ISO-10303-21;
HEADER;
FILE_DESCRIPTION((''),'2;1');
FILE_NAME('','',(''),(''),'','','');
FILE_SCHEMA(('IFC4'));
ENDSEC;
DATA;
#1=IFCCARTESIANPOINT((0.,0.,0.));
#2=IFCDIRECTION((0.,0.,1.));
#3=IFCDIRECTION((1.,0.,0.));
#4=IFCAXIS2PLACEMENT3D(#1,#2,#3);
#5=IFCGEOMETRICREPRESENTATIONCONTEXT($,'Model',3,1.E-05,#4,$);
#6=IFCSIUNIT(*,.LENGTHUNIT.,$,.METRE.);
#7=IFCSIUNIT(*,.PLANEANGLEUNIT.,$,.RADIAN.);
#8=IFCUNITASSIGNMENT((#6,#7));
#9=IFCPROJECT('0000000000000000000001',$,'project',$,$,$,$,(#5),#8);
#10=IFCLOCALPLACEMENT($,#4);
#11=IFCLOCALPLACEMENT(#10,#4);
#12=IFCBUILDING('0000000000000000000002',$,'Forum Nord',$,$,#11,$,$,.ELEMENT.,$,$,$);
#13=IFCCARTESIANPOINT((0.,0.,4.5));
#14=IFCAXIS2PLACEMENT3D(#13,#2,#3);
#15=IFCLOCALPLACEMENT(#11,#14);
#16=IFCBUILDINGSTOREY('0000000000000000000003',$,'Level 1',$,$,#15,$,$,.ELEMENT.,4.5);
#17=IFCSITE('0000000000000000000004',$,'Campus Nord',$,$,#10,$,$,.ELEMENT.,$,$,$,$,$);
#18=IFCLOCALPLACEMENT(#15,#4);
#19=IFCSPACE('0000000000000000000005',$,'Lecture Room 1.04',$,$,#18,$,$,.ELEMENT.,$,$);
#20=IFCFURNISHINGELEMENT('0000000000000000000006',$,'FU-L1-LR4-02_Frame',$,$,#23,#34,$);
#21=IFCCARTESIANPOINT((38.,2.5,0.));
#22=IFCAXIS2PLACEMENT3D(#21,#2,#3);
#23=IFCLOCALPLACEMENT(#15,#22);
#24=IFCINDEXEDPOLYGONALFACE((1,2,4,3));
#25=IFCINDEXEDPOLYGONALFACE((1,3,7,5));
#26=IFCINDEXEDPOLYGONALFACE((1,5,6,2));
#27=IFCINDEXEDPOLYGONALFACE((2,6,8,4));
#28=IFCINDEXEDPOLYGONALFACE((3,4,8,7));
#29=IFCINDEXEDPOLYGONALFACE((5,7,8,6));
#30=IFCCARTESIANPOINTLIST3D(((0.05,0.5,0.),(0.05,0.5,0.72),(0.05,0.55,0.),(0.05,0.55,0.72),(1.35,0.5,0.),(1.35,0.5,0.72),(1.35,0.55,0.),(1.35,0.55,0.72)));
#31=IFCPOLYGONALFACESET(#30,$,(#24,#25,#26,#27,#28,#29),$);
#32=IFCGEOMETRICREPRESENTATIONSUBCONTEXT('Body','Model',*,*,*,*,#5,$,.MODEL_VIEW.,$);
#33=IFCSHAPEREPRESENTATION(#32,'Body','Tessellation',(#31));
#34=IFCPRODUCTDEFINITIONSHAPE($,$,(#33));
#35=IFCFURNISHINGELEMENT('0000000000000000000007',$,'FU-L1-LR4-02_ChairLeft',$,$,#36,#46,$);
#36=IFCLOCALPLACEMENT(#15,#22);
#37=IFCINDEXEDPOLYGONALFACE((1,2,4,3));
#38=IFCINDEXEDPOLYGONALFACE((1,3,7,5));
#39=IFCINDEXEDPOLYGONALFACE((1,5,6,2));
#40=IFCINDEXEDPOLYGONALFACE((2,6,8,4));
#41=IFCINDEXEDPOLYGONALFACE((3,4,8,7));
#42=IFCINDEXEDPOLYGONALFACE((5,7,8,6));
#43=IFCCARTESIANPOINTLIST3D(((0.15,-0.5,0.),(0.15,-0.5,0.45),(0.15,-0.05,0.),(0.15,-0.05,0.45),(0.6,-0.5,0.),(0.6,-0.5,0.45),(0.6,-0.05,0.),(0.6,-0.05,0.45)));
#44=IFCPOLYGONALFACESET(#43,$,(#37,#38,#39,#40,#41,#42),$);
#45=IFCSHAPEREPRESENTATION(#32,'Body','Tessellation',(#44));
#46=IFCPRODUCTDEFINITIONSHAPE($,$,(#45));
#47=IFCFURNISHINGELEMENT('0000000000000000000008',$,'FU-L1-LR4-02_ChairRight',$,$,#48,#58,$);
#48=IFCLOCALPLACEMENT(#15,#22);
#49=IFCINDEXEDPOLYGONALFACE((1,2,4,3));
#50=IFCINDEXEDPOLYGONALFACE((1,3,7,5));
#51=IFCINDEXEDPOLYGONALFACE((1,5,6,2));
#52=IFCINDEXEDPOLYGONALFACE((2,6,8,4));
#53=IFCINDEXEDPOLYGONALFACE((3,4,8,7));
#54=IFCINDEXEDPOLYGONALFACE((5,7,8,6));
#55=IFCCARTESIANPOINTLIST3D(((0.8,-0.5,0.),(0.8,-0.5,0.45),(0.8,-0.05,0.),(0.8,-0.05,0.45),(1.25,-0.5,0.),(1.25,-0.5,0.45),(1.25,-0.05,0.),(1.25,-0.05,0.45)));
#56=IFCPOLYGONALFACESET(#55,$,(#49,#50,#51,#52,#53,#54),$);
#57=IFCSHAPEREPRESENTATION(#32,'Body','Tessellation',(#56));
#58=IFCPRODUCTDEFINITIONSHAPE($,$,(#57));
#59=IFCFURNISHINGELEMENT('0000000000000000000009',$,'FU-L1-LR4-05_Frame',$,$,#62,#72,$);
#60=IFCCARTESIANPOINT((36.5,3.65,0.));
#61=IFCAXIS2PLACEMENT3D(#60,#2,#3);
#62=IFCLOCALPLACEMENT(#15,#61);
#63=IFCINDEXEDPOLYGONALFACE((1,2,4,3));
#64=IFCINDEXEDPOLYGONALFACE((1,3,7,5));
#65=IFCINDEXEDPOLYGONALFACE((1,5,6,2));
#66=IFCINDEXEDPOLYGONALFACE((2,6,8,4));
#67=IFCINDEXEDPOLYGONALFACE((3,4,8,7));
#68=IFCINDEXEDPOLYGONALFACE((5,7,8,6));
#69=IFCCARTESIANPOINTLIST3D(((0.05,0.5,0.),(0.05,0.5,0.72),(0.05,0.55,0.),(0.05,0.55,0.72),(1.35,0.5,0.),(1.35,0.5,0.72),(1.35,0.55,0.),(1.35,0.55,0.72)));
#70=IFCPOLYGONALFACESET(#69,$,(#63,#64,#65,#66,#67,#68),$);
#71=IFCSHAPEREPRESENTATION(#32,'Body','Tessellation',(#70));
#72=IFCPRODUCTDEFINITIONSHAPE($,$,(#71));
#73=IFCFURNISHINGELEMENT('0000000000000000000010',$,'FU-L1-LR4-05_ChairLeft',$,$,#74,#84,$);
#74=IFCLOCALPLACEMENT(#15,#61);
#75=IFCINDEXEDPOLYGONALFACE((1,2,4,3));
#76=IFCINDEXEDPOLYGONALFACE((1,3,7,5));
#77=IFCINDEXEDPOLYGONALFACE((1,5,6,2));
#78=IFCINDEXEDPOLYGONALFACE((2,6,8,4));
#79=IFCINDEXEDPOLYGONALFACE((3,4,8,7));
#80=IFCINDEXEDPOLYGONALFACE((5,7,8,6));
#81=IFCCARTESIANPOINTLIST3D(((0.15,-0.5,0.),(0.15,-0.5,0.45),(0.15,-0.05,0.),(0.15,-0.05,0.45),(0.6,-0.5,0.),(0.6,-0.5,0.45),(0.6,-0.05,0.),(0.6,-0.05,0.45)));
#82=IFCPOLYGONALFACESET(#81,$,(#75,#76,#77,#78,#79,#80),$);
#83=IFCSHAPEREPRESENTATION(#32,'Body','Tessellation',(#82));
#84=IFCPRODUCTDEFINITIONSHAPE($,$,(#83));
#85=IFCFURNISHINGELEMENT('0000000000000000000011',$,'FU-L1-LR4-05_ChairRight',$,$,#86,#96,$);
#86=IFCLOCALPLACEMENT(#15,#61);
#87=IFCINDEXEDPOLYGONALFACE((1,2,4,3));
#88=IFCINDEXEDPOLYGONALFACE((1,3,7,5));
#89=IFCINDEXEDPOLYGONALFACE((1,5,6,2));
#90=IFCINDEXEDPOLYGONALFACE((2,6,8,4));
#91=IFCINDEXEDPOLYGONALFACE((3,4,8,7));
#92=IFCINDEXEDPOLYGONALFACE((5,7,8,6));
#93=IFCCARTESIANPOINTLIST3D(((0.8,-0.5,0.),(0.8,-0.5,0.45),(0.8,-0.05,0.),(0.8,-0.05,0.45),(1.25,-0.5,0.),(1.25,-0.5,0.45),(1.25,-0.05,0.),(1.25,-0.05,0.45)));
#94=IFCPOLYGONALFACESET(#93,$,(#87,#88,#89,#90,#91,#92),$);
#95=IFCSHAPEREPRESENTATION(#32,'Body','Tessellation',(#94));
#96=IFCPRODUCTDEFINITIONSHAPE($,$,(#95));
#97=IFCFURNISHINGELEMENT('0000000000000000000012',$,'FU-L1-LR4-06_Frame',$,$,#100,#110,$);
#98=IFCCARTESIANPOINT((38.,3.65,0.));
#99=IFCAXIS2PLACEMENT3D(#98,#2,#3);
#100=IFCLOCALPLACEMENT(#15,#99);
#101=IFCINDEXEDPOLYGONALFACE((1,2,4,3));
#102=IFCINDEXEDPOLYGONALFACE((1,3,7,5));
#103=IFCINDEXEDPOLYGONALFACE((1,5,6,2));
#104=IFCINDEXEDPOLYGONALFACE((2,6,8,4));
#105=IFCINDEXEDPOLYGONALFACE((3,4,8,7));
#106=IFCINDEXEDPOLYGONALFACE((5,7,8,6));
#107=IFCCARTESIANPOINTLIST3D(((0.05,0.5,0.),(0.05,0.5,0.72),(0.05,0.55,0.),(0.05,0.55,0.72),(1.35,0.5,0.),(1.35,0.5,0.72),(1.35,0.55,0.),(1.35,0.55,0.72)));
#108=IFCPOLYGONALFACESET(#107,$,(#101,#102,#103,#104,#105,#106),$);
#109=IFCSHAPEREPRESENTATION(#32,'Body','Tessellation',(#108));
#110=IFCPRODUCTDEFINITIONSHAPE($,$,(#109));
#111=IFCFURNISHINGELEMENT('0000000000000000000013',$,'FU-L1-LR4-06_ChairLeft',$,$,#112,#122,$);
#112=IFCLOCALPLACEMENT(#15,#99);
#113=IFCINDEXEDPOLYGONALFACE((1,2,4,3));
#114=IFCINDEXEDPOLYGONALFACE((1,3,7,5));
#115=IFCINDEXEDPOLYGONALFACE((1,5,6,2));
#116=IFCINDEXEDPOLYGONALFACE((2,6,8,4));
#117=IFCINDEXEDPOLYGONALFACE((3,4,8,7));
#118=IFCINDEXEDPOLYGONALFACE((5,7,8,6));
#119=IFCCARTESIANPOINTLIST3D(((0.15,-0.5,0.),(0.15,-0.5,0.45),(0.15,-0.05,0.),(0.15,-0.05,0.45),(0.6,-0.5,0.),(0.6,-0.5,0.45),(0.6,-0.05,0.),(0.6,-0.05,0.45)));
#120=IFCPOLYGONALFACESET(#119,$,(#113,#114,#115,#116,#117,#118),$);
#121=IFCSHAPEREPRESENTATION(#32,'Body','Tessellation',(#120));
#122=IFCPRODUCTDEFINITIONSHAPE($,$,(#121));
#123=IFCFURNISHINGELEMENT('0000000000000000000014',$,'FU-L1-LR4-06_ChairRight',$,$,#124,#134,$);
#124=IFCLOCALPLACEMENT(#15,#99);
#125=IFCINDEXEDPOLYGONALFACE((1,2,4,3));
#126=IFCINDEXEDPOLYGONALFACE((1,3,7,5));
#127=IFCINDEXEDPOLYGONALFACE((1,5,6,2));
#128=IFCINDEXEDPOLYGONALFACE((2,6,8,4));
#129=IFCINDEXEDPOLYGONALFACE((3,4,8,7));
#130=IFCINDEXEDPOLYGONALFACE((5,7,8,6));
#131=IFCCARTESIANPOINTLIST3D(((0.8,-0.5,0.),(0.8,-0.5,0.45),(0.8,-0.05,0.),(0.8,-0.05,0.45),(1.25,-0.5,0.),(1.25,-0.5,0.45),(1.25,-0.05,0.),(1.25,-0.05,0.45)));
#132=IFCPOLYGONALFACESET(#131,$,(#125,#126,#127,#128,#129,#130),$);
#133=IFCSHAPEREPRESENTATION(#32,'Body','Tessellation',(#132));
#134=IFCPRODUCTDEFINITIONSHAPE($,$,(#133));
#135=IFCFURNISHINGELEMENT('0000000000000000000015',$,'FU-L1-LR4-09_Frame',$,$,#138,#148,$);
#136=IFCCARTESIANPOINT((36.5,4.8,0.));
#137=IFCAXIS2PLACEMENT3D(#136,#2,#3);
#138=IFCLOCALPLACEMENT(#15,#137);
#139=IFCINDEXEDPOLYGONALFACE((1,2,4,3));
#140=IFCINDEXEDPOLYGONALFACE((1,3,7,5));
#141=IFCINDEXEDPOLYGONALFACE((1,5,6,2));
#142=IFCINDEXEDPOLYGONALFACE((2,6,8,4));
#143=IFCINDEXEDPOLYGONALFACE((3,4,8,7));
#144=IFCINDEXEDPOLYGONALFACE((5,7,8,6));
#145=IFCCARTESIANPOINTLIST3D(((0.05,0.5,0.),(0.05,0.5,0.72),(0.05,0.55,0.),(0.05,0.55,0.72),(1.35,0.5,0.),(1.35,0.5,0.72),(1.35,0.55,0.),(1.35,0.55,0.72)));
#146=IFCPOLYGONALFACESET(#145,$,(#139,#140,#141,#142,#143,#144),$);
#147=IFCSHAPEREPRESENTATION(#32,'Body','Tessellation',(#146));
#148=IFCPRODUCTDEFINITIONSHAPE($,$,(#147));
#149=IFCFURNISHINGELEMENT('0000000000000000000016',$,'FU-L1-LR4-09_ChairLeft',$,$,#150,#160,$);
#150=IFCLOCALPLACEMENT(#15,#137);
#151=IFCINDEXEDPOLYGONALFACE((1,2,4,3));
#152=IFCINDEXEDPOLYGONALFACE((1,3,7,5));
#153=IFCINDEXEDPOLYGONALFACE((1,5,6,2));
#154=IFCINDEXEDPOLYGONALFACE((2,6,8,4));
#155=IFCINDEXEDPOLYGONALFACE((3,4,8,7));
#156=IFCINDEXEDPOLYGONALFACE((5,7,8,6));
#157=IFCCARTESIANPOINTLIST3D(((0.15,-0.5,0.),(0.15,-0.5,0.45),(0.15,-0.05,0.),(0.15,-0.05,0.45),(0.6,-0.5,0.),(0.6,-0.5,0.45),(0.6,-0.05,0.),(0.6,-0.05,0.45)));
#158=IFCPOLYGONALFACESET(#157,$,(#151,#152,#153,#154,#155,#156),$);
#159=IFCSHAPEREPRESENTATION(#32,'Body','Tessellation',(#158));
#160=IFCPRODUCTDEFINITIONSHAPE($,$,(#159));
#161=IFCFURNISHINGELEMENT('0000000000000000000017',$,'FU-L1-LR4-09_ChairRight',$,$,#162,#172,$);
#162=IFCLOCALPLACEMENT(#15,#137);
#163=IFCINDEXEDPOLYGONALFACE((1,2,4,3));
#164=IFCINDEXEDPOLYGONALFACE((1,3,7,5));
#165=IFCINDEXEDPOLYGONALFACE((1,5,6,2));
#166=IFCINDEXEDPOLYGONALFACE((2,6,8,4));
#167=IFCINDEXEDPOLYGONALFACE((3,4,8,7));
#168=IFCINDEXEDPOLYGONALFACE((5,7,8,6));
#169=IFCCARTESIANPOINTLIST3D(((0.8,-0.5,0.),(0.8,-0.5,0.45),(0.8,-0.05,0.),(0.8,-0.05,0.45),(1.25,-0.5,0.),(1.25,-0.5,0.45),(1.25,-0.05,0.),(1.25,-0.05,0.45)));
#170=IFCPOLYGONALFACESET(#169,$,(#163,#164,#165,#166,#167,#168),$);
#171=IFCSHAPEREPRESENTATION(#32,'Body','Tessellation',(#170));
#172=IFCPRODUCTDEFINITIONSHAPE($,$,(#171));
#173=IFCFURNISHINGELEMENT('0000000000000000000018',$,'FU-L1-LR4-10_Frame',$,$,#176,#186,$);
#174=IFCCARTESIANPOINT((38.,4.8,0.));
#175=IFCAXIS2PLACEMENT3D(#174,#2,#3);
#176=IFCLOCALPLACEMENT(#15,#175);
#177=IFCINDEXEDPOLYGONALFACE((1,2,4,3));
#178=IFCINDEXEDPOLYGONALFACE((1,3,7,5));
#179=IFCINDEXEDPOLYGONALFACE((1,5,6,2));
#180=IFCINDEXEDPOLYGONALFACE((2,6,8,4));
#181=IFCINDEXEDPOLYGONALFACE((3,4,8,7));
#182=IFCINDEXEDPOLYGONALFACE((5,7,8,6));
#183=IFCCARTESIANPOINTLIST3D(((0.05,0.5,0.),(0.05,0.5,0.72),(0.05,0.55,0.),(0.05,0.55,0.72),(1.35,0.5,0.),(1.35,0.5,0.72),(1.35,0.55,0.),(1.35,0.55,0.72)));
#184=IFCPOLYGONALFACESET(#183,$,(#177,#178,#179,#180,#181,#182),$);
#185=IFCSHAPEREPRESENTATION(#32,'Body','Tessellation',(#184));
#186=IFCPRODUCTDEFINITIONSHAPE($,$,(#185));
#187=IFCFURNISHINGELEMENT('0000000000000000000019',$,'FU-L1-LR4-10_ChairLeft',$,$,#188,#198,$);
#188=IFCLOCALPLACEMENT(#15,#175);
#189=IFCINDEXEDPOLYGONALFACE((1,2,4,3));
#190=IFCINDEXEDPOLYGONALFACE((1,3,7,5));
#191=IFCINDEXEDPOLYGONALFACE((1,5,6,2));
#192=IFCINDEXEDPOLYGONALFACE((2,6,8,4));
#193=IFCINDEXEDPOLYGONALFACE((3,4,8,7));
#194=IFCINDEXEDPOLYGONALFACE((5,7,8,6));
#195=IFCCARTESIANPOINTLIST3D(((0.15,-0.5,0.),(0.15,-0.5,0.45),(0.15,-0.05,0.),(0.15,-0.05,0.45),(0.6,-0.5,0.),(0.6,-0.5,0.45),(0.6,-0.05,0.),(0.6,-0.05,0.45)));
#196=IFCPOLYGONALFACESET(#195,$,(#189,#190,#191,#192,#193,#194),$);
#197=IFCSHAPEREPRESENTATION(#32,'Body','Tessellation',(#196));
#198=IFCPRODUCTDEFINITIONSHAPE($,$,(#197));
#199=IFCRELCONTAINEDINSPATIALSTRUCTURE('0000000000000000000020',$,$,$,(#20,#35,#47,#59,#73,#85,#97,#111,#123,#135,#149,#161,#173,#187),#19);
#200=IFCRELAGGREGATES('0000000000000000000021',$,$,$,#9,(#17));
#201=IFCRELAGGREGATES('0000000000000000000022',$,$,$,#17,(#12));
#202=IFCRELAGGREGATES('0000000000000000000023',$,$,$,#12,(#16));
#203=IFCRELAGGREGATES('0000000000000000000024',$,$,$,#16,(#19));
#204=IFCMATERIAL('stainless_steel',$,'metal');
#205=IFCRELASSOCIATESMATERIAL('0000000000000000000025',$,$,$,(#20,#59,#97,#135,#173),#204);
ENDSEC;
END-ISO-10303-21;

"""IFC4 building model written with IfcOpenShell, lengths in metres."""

from ifc_helpers import new_model, si_unit, frame, frame_2d, origin_with_axes, place, context, subcontext, project, spatial, rectangle, extrude, material, element, save


model = new_model("IFC4")

# Units and contexts
model_context = context("Model", 3, precision=1e-05, world=origin_with_axes())
body_context = subcontext(model_context, "Body", "Model", "MODEL_VIEW")
ifc_project = project(units=[si_unit("LENGTHUNIT", "METRE"), si_unit("PLANEANGLEUNIT", "RADIAN")], contexts=[model_context])

# Site, building, storey
site_placement = place(None, origin_with_axes())
site = spatial("IfcSite", under=ifc_project, at=site_placement, Name="Campus Nord", CompositionType="ELEMENT")
building_placement = place(site_placement, origin_with_axes())
building = spatial("IfcBuilding", under=site, at=building_placement, Name="Forum Nord", CompositionType="ELEMENT")
storey_placement = place(building_placement, frame((0.0, 0.0, 4.5), z_axis=(0.0, 0.0, 1.0), x_axis=(1.0, 0.0, 0.0)))
storey = spatial("IfcBuildingStorey", under=building, at=storey_placement, Name="Level 1", CompositionType="ELEMENT", Elevation=4.5)

# Shared definitions
ifc_material_1 = material(Name="stainless_steel", Category="metal")

# Shared definitions
space_placement = place(storey_placement, origin_with_axes())
space = spatial("IfcSpace", under=storey, at=space_placement, Name="Lecture Room 1.04", CompositionType="ELEMENT")

# Furnishing elements
furnishing_1_placement = place(storey_placement, frame((38.0, 2.5, 0.0), z_axis=(0.0, 0.0, 1.0), x_axis=(1.0, 0.0, 0.0)))
element("IfcFurnishingElement", 1, at=furnishing_1_placement, inside=space, material=ifc_material_1, Name="FU-L1-LR4-02_Frame", context=body_context, shape_type="SweptSolid", body=[
    extrude(rectangle(XDim=1.3, YDim=0.05, at=frame_2d((0.7, 0.525), x_axis=(1.0, 0.0))), origin_with_axes(), (0.0, 0.0, 1.0), 0.72),
])
furnishing_2_placement = place(storey_placement, frame((38.0, 2.5, 0.0), z_axis=(0.0, 0.0, 1.0), x_axis=(1.0, 0.0, 0.0)))
element("IfcFurnishingElement", 2, at=furnishing_2_placement, inside=space, Name="FU-L1-LR4-02_ChairLeft", context=body_context, shape_type="SweptSolid", body=[
    extrude(rectangle(XDim=0.45, YDim=0.45, at=frame_2d((0.375, -0.275), x_axis=(1.0, 0.0))), origin_with_axes(), (0.0, 0.0, 1.0), 0.45),
])
furnishing_3_placement = place(storey_placement, frame((38.0, 2.5, 0.0), z_axis=(0.0, 0.0, 1.0), x_axis=(1.0, 0.0, 0.0)))
element("IfcFurnishingElement", 3, at=furnishing_3_placement, inside=space, Name="FU-L1-LR4-02_ChairRight", context=body_context, shape_type="SweptSolid", body=[
    extrude(rectangle(XDim=0.45, YDim=0.45, at=frame_2d((1.025, -0.275), x_axis=(1.0, 0.0))), origin_with_axes(), (0.0, 0.0, 1.0), 0.45),
])
furnishing_4_placement = place(storey_placement, frame((36.5, 3.65, 0.0), z_axis=(0.0, 0.0, 1.0), x_axis=(1.0, 0.0, 0.0)))
element("IfcFurnishingElement", 4, at=furnishing_4_placement, inside=space, material=ifc_material_1, Name="FU-L1-LR4-05_Frame", context=body_context, shape_type="SweptSolid", body=[
    extrude(rectangle(XDim=1.3, YDim=0.05, at=frame_2d((0.7, 0.525), x_axis=(1.0, 0.0))), origin_with_axes(), (0.0, 0.0, 1.0), 0.72),
])
furnishing_5_placement = place(storey_placement, frame((36.5, 3.65, 0.0), z_axis=(0.0, 0.0, 1.0), x_axis=(1.0, 0.0, 0.0)))
element("IfcFurnishingElement", 5, at=furnishing_5_placement, inside=space, Name="FU-L1-LR4-05_ChairLeft", context=body_context, shape_type="SweptSolid", body=[
    extrude(rectangle(XDim=0.45, YDim=0.45, at=frame_2d((0.375, -0.275), x_axis=(1.0, 0.0))), origin_with_axes(), (0.0, 0.0, 1.0), 0.45),
])
furnishing_6_placement = place(storey_placement, frame((36.5, 3.65, 0.0), z_axis=(0.0, 0.0, 1.0), x_axis=(1.0, 0.0, 0.0)))
element("IfcFurnishingElement", 6, at=furnishing_6_placement, inside=space, Name="FU-L1-LR4-05_ChairRight", context=body_context, shape_type="SweptSolid", body=[
    extrude(rectangle(XDim=0.45, YDim=0.45, at=frame_2d((1.025, -0.275), x_axis=(1.0, 0.0))), origin_with_axes(), (0.0, 0.0, 1.0), 0.45),
])
furnishing_7_placement = place(storey_placement, frame((38.0, 3.65, 0.0), z_axis=(0.0, 0.0, 1.0), x_axis=(1.0, 0.0, 0.0)))
element("IfcFurnishingElement", 7, at=furnishing_7_placement, inside=space, material=ifc_material_1, Name="FU-L1-LR4-06_Frame", context=body_context, shape_type="SweptSolid", body=[
    extrude(rectangle(XDim=1.3, YDim=0.05, at=frame_2d((0.7, 0.525), x_axis=(1.0, 0.0))), origin_with_axes(), (0.0, 0.0, 1.0), 0.72),
])
furnishing_8_placement = place(storey_placement, frame((38.0, 3.65, 0.0), z_axis=(0.0, 0.0, 1.0), x_axis=(1.0, 0.0, 0.0)))
element("IfcFurnishingElement", 8, at=furnishing_8_placement, inside=space, Name="FU-L1-LR4-06_ChairLeft", context=body_context, shape_type="SweptSolid", body=[
    extrude(rectangle(XDim=0.45, YDim=0.45, at=frame_2d((0.375, -0.275), x_axis=(1.0, 0.0))), origin_with_axes(), (0.0, 0.0, 1.0), 0.45),
])
furnishing_9_placement = place(storey_placement, frame((38.0, 3.65, 0.0), z_axis=(0.0, 0.0, 1.0), x_axis=(1.0, 0.0, 0.0)))
element("IfcFurnishingElement", 9, at=furnishing_9_placement, inside=space, Name="FU-L1-LR4-06_ChairRight", context=body_context, shape_type="SweptSolid", body=[
    extrude(rectangle(XDim=0.45, YDim=0.45, at=frame_2d((1.025, -0.275), x_axis=(1.0, 0.0))), origin_with_axes(), (0.0, 0.0, 1.0), 0.45),
])
furnishing_10_placement = place(storey_placement, frame((36.5, 4.8, 0.0), z_axis=(0.0, 0.0, 1.0), x_axis=(1.0, 0.0, 0.0)))
element("IfcFurnishingElement", 10, at=furnishing_10_placement, inside=space, material=ifc_material_1, Name="FU-L1-LR4-09_Frame", context=body_context, shape_type="SweptSolid", body=[
    extrude(rectangle(XDim=1.3, YDim=0.05, at=frame_2d((0.7, 0.525), x_axis=(1.0, 0.0))), origin_with_axes(), (0.0, 0.0, 1.0), 0.72),
])
furnishing_11_placement = place(storey_placement, frame((36.5, 4.8, 0.0), z_axis=(0.0, 0.0, 1.0), x_axis=(1.0, 0.0, 0.0)))
element("IfcFurnishingElement", 11, at=furnishing_11_placement, inside=space, Name="FU-L1-LR4-09_ChairLeft", context=body_context, shape_type="SweptSolid", body=[
    extrude(rectangle(XDim=0.45, YDim=0.45, at=frame_2d((0.375, -0.275), x_axis=(1.0, 0.0))), origin_with_axes(), (0.0, 0.0, 1.0), 0.45),
])
furnishing_12_placement = place(storey_placement, frame((36.5, 4.8, 0.0), z_axis=(0.0, 0.0, 1.0), x_axis=(1.0, 0.0, 0.0)))
element("IfcFurnishingElement", 12, at=furnishing_12_placement, inside=space, Name="FU-L1-LR4-09_ChairRight", context=body_context, shape_type="SweptSolid", body=[
    extrude(rectangle(XDim=0.45, YDim=0.45, at=frame_2d((1.025, -0.275), x_axis=(1.0, 0.0))), origin_with_axes(), (0.0, 0.0, 1.0), 0.45),
])
furnishing_13_placement = place(storey_placement, frame((38.0, 4.8, 0.0), z_axis=(0.0, 0.0, 1.0), x_axis=(1.0, 0.0, 0.0)))
element("IfcFurnishingElement", 13, at=furnishing_13_placement, inside=space, material=ifc_material_1, Name="FU-L1-LR4-10_Frame", context=body_context, shape_type="SweptSolid", body=[
    extrude(rectangle(XDim=1.3, YDim=0.05, at=frame_2d((0.7, 0.525), x_axis=(1.0, 0.0))), origin_with_axes(), (0.0, 0.0, 1.0), 0.72),
])
furnishing_14_placement = place(storey_placement, frame((38.0, 4.8, 0.0), z_axis=(0.0, 0.0, 1.0), x_axis=(1.0, 0.0, 0.0)))
element("IfcFurnishingElement", 14, at=furnishing_14_placement, inside=space, Name="FU-L1-LR4-10_ChairLeft", context=body_context, shape_type="SweptSolid", body=[
    extrude(rectangle(XDim=0.45, YDim=0.45, at=frame_2d((0.375, -0.275), x_axis=(1.0, 0.0))), origin_with_axes(), (0.0, 0.0, 1.0), 0.45),
])

save(model, "model.ifc")
